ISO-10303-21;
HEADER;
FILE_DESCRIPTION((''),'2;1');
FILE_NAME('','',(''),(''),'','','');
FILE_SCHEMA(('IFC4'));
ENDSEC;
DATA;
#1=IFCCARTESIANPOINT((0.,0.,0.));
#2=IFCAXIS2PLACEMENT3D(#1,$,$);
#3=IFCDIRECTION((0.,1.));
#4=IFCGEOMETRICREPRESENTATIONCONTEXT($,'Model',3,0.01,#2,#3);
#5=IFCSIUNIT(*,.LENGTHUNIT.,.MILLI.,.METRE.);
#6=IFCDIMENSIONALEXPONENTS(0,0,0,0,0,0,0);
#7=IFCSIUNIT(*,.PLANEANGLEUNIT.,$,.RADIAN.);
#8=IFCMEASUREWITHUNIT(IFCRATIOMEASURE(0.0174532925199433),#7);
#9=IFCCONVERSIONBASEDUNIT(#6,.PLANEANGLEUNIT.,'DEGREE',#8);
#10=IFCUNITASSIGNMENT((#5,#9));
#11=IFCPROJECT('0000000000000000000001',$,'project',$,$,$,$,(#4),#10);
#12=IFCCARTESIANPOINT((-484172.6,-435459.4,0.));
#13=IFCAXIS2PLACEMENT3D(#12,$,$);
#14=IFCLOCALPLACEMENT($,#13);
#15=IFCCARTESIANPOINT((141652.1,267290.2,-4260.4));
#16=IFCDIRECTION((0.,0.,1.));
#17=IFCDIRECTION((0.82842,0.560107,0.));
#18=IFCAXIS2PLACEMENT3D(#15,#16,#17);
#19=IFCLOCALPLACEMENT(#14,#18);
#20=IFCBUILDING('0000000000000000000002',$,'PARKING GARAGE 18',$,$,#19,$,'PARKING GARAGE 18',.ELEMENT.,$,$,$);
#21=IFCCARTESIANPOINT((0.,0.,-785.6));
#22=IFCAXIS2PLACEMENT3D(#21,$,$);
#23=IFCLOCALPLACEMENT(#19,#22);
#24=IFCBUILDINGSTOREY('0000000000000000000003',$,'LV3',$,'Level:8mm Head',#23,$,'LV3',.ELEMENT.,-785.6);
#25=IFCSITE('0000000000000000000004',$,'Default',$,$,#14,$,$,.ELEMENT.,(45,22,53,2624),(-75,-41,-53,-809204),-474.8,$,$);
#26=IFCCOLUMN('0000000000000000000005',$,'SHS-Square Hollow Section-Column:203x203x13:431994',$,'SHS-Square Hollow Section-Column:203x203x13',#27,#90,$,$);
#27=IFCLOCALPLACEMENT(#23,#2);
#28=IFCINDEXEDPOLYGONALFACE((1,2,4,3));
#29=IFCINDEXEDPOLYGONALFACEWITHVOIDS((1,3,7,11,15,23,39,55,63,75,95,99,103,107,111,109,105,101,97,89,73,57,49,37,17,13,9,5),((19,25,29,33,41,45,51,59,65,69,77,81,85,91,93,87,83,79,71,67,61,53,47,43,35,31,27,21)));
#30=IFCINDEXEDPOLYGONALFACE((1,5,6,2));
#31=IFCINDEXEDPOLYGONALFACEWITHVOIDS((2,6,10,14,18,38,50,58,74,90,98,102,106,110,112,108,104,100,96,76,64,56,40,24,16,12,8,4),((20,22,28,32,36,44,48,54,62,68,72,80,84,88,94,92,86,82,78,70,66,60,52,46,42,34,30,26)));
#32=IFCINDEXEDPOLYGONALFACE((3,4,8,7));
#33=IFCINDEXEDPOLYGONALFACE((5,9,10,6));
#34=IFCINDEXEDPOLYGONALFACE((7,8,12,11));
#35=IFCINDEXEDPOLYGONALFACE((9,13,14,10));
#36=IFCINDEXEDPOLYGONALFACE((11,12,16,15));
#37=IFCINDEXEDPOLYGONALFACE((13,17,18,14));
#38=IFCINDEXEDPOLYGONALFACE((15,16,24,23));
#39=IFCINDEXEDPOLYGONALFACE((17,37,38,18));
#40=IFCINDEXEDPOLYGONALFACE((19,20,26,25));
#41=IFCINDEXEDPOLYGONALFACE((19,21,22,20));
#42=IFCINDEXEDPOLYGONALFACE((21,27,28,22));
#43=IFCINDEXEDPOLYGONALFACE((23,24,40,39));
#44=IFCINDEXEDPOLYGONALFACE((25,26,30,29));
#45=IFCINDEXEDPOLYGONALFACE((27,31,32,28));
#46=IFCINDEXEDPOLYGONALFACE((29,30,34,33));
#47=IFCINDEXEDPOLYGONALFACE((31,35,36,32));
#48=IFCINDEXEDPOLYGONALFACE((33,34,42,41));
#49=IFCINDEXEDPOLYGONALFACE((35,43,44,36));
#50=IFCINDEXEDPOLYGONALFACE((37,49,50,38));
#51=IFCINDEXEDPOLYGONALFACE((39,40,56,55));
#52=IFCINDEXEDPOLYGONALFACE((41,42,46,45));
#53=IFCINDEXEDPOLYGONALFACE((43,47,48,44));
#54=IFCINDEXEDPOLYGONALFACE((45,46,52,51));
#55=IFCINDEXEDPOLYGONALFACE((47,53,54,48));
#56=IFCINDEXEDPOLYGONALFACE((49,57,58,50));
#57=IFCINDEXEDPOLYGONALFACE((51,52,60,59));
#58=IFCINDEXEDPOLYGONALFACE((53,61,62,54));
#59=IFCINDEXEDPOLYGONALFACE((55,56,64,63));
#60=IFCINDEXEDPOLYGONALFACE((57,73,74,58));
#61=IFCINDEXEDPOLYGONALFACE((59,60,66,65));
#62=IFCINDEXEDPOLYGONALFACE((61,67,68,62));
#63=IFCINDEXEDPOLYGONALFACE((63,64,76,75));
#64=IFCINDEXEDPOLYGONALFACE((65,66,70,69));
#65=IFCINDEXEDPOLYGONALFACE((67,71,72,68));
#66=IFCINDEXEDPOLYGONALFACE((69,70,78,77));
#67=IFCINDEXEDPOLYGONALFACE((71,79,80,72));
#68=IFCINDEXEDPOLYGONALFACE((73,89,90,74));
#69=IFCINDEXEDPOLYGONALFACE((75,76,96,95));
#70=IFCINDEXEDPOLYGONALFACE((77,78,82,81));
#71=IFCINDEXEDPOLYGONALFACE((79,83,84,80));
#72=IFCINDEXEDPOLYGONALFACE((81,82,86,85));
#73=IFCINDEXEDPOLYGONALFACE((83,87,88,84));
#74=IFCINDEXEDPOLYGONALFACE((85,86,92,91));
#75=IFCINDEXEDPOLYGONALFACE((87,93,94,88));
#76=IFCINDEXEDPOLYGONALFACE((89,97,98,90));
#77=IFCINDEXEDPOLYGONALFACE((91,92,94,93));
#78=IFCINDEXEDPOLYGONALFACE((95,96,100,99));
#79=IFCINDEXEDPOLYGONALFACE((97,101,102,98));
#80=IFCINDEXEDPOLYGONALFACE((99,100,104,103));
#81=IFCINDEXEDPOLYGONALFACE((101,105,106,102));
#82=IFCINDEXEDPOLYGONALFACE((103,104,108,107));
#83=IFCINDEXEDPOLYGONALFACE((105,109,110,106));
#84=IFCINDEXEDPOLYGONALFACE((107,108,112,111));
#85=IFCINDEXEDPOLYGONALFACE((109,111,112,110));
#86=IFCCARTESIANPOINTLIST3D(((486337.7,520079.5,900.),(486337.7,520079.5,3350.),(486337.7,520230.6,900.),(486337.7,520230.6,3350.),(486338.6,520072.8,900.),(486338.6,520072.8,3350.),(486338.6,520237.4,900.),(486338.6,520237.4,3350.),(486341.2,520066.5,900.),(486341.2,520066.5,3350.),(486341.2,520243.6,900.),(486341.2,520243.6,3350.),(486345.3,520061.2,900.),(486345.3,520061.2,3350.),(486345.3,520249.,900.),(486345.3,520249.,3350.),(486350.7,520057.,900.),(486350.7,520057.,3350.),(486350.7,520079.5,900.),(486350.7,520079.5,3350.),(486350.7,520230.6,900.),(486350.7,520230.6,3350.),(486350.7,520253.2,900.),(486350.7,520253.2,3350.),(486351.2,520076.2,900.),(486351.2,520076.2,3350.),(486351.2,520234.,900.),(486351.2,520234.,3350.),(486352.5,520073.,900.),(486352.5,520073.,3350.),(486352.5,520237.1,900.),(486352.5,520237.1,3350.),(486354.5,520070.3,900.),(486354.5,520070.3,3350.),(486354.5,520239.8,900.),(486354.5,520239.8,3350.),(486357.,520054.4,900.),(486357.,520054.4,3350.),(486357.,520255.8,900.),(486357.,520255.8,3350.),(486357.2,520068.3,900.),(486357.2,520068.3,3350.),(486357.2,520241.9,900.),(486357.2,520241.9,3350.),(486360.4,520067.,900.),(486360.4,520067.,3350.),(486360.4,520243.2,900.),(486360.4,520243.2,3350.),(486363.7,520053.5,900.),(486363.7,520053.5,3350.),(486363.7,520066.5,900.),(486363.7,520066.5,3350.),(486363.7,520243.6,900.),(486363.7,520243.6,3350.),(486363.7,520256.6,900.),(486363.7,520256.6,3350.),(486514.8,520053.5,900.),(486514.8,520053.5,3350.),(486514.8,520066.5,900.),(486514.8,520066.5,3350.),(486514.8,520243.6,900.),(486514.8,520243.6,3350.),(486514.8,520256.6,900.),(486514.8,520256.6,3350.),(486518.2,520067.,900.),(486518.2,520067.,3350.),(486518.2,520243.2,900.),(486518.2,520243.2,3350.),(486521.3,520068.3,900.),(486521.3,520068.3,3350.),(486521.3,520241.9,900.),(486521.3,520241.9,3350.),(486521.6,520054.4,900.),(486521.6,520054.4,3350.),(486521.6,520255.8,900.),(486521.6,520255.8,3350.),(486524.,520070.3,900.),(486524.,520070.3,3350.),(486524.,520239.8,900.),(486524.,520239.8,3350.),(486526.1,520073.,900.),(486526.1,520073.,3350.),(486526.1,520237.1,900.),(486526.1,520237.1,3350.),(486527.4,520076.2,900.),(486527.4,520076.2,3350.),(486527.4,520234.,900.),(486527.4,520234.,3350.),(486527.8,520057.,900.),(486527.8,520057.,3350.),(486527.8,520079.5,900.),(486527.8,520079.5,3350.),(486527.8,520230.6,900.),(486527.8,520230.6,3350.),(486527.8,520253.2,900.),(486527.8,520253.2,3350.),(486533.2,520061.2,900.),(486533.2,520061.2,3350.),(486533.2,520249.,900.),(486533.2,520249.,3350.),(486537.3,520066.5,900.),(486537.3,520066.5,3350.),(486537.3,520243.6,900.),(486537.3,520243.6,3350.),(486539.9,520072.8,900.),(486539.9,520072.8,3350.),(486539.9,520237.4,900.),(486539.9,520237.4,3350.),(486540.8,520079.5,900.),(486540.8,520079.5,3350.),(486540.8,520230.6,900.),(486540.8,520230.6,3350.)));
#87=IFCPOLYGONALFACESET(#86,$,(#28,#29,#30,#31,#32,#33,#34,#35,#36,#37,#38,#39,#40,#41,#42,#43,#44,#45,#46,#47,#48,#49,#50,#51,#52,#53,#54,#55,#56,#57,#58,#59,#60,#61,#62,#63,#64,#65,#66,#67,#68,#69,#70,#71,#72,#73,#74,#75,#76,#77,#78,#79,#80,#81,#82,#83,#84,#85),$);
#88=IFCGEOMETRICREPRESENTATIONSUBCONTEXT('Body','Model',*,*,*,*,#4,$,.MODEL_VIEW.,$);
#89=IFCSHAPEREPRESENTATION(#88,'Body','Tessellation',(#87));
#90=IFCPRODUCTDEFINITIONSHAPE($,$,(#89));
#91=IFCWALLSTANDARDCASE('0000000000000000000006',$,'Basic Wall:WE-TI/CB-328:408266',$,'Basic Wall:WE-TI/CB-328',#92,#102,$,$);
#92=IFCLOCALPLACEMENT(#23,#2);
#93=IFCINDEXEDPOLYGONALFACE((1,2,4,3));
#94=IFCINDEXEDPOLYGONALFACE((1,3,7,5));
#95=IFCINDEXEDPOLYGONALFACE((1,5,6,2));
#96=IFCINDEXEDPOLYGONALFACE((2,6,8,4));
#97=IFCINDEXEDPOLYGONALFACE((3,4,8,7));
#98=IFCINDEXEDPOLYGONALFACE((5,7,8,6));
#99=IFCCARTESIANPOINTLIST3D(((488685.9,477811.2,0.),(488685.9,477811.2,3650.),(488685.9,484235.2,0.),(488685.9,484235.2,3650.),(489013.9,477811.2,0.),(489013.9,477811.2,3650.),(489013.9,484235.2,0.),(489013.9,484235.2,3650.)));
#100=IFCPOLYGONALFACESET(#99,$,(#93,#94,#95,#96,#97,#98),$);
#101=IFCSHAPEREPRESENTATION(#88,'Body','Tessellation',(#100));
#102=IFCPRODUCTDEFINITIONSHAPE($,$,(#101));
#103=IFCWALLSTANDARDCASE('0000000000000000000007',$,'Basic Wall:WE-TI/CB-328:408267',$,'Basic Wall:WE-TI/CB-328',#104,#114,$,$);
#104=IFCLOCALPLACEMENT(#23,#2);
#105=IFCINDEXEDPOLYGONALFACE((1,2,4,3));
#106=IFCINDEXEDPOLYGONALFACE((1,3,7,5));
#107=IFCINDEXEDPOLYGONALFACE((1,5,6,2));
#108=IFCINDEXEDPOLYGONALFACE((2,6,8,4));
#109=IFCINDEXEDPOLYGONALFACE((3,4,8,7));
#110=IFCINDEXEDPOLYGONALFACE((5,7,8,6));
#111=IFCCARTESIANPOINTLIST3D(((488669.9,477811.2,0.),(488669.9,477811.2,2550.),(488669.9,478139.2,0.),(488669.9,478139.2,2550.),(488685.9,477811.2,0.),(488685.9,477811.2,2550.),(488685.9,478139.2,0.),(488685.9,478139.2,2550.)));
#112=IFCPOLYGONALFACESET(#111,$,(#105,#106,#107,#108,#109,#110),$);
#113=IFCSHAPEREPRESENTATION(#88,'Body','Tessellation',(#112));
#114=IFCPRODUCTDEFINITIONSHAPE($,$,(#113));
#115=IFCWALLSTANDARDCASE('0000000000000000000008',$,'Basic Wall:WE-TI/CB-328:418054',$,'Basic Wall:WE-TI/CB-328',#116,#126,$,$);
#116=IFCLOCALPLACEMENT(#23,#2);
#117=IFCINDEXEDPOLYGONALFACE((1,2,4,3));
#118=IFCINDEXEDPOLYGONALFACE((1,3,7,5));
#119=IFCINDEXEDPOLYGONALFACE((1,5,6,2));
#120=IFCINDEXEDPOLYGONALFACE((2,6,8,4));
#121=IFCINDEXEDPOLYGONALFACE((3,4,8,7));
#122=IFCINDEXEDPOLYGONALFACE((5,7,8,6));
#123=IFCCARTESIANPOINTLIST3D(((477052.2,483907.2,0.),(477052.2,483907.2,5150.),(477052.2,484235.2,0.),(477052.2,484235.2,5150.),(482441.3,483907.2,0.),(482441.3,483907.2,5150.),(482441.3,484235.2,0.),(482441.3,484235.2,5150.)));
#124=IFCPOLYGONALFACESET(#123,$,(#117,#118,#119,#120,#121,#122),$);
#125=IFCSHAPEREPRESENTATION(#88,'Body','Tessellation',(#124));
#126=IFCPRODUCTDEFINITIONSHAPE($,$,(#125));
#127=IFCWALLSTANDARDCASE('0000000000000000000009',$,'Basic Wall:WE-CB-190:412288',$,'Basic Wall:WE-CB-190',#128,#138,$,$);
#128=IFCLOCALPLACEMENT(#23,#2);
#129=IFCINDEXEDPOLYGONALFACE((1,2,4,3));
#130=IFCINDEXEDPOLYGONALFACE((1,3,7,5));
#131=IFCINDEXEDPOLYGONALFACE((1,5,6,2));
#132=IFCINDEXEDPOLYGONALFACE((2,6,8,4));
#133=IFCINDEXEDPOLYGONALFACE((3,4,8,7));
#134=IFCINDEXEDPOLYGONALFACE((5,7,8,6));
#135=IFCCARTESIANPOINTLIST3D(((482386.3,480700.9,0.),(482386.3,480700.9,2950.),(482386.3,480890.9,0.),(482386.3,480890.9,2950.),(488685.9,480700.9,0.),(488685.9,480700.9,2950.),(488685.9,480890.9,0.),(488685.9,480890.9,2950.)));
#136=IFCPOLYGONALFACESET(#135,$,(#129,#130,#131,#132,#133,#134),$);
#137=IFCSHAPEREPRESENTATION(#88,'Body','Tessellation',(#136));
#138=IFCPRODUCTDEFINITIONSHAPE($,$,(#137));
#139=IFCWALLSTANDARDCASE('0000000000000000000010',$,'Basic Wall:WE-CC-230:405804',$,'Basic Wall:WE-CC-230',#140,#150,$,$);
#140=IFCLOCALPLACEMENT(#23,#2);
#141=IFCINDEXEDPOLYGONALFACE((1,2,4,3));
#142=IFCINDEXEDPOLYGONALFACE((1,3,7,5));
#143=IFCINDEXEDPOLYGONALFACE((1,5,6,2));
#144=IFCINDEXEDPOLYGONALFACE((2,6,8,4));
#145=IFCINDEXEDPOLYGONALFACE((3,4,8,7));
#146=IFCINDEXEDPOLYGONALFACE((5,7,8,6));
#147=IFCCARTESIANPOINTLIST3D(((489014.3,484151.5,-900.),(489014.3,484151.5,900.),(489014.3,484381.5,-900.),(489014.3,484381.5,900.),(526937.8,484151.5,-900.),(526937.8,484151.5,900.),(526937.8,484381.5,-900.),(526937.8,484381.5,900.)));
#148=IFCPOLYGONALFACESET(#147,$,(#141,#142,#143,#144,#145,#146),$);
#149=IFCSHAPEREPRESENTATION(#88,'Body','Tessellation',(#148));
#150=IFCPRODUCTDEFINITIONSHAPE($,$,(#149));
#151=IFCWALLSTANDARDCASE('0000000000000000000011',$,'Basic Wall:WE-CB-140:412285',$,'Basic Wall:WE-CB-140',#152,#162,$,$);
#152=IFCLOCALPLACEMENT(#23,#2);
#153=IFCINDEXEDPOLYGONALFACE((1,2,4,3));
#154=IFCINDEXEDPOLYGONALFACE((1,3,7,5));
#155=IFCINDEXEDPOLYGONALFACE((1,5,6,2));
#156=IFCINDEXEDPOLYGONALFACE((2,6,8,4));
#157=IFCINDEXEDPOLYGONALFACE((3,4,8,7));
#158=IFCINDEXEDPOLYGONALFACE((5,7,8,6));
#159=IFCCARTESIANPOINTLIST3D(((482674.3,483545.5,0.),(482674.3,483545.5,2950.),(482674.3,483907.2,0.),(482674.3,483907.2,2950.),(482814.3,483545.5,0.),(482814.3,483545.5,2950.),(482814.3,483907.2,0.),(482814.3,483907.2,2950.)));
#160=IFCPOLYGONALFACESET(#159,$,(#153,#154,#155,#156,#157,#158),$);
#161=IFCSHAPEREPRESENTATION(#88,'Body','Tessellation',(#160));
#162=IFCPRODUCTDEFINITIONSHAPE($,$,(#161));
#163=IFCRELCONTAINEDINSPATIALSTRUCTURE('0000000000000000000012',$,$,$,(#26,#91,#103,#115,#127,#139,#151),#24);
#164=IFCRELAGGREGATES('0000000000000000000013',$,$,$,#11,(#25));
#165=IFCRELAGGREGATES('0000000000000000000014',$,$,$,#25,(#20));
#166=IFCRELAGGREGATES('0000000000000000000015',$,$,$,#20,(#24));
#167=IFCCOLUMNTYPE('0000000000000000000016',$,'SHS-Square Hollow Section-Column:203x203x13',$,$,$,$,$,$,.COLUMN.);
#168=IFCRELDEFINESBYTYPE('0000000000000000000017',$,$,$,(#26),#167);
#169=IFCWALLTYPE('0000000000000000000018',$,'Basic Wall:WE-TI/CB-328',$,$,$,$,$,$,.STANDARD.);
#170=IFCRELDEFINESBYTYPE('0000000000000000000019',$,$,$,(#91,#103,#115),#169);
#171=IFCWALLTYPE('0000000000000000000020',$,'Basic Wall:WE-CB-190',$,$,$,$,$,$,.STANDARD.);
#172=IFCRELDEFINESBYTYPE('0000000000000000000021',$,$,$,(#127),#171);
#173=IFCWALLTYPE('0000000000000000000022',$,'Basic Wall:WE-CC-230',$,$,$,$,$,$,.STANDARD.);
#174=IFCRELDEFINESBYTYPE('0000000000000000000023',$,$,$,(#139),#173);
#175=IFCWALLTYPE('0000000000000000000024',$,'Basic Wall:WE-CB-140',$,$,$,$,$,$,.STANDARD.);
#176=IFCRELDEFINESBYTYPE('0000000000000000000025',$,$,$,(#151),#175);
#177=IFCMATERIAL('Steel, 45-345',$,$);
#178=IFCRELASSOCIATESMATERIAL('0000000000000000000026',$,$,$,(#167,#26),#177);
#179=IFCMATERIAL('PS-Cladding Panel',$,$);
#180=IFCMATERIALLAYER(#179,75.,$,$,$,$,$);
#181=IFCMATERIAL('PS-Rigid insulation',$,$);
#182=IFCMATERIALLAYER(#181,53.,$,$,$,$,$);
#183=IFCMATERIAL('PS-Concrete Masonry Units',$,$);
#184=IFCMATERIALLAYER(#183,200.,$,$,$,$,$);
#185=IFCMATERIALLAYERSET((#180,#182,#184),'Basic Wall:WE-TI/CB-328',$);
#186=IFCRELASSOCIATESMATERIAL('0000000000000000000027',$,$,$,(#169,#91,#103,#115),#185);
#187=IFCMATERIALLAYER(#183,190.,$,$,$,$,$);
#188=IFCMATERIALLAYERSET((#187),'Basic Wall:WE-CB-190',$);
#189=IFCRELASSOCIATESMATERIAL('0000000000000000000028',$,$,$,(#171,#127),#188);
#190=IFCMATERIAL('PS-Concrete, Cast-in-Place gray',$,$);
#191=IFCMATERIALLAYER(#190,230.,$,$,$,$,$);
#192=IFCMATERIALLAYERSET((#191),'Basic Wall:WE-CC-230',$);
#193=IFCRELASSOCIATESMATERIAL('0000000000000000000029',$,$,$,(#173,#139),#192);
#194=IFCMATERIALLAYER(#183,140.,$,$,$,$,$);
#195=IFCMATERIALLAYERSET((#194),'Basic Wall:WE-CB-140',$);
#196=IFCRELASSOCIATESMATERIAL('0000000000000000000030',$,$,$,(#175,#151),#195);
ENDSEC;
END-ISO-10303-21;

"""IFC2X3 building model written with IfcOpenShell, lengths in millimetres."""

from ifc_helpers import new_model, entity, si_unit, converted_unit, direction, frame, frame_2d, origin, place, context, subcontext, project, spatial, polyline, circle_curve, parameter, trimmed, segment, composite_curve, rectangle, outline, extrude, clip, bounded_halfspace, source, transform, mapped, material, layer, layer_set, layer_usage, type_object, type_shapes, element, save


model = new_model("IFC2X3")

# Units and contexts
model_context = context("Model", 3, precision=0.01, world=origin(), true_north=direction((0.0, 1.0)))
body_context = subcontext(model_context, "Body", "Model", "MODEL_VIEW")
ifc_project = project(units=[si_unit("LENGTHUNIT", "METRE", prefix="MILLI"), converted_unit("PLANEANGLEUNIT", "DEGREE", entity("IfcRatioMeasure", 0.0174532925199433), si_unit("PLANEANGLEUNIT", "RADIAN"), dimensions=[0, 0, 0, 0, 0, 0, 0])], contexts=[model_context])

# Site, building, storey
site_placement = place(None, frame((-484172.6, -435459.4, 0.0)))
site = spatial("IfcSite", under=ifc_project, at=site_placement, Name="Default", CompositionType="ELEMENT", RefLatitude=(45, 22, 53, 2624), RefLongitude=(-75, -41, -53, -809204), RefElevation=-474.8)
building_placement = place(site_placement, frame((141652.1, 267290.2, -4260.4), z_axis=(0.0, 0.0, 1.0), x_axis=(0.82842, 0.560107, 0.0)))
building = spatial("IfcBuilding", under=site, at=building_placement, Name="PARKING GARAGE 18", LongName="PARKING GARAGE 18", CompositionType="ELEMENT")
storey_placement = place(building_placement, frame((0.0, 0.0, -785.6)))
storey = spatial("IfcBuildingStorey", under=building, at=storey_placement, Name="LV3", ObjectType="Level:8mm Head", LongName="LV3", CompositionType="ELEMENT", Elevation=-785.6)

# Column
ifc_material_1 = material(Name="Steel, 45-345")
column_type_1 = type_object("IfcColumnType", Name="SHS-Square Hollow Section-Column:203x203x13", PredefinedType="COLUMN", material=ifc_material_1)
shared_shape_1 = source(origin(), body_context, "Body", "SweptSolid", [
    extrude(outline(composite_curve([segment(polyline([(-75.6, -101.5), (75.6, -101.5)]), True, "CONTINUOUS"), segment(trimmed(circle_curve(frame_2d((75.6, -75.6), x_axis=(-1.0, 0.0)), 26.0), [parameter(90.0)], [parameter(180.0)], True, "PARAMETER"), True, "CONTINUOUS"), segment(polyline([(101.5, -75.6), (101.5, 75.6)]), True, "CONTINUOUS"), segment(trimmed(circle_curve(frame_2d((75.5, 75.6), x_axis=(-1.0, 0.0)), 26.0), [parameter(180.0)], [parameter(270.0)], True, "PARAMETER"), True, "CONTINUOUS"), segment(polyline([(75.5, 101.6), (-75.5, 101.6)]), True, "CONTINUOUS"), segment(trimmed(circle_curve(frame_2d((-75.5, 75.5), x_axis=(-1.0, 0.0)), 26.0), [parameter(270.0)], [parameter(360.0)], True, "PARAMETER"), True, "CONTINUOUS"), segment(polyline([(-101.5, 75.5), (-101.5, -75.6)]), True, "CONTINUOUS"), segment(trimmed(circle_curve(frame_2d((-75.6, -75.6), x_axis=(-1.0, 0.0)), 26.0), [parameter(360.0)], [parameter(90.0)], True, "PARAMETER"), True, "CONTINUOUS")], self_intersect=False), holes=[composite_curve([segment(trimmed(circle_curve(frame_2d((-75.6, -75.6), x_axis=(-1.0, 0.0)), 13.0), [parameter(0.0)], [parameter(90.0)], True, "PARAMETER"), False, "CONTINUOUS"), segment(polyline([(-88.5, -75.6), (-88.5, 75.6)]), True, "CONTINUOUS"), segment(trimmed(circle_curve(frame_2d((-75.6, 75.6), x_axis=(-1.0, 0.0)), 13.0), [parameter(270.0)], [parameter(0.0)], True, "PARAMETER"), False, "CONTINUOUS"), segment(polyline([(-75.6, 88.6), (75.5, 88.6)]), True, "CONTINUOUS"), segment(trimmed(circle_curve(frame_2d((75.5, 75.5), x_axis=(-1.0, 0.0)), 13.0), [parameter(180.0)], [parameter(270.0)], True, "PARAMETER"), False, "CONTINUOUS"), segment(polyline([(88.6, 75.5), (88.6, -75.5)]), True, "CONTINUOUS"), segment(trimmed(circle_curve(frame_2d((75.6, -75.5), x_axis=(-1.0, 0.0)), 13.0), [parameter(90.0)], [parameter(180.0)], True, "PARAMETER"), False, "CONTINUOUS"), segment(polyline([(75.6, -88.5), (-75.6, -88.5)]), True, "CONTINUOUS")], self_intersect=False)]), frame((0.0, 0.0, 114.4), z_axis=(0.0, 0.0, 1.0), x_axis=(-1.0, 0.0, 0.0)), (0.0, 0.0, 1.0), 2450.0),
])
type_shapes(column_type_1, [shared_shape_1])
column_placement = place(storey_placement, frame((486439.3, 520155.1, 785.6)))
element("IfcColumn", 1, at=column_placement, inside=storey, type_object=column_type_1, material=ifc_material_1, Name="SHS-Square Hollow Section-Column:203x203x13:431994", ObjectType="SHS-Square Hollow Section-Column:203x203x13", context=body_context, shape_type="MappedRepresentation", body=[
    mapped(shared_shape_1, transform((0.0, 0.0, 0.0), scale=1.0)),
])

# Walls
ifc_material_2 = material(Name="PS-Cladding Panel")
ifc_layer_1 = layer(ifc_material_2, 75.0)
ifc_material_3 = material(Name="PS-Rigid insulation")
ifc_layer_2 = layer(ifc_material_3, 53.0)
ifc_material_4 = material(Name="PS-Concrete Masonry Units")
ifc_layer_3 = layer(ifc_material_4, 200.0)
ifc_layer_set_1 = layer_set([ifc_layer_1, ifc_layer_2, ifc_layer_3], Name="Basic Wall:WE-TI/CB-328")
ifc_layer_usage_1 = layer_usage(ifc_layer_set_1, "AXIS2", "NEGATIVE", 164.0)
wall_type_1 = type_object("IfcWallType", Name="Basic Wall:WE-TI/CB-328", PredefinedType="STANDARD", material=ifc_layer_set_1)
wall_1_placement = place(storey_placement, frame((488849.9, 484235.2, 0.0), z_axis=(0.0, 0.0, 1.0), x_axis=(0.0, -1.0, 0.0)))
element("IfcWallStandardCase", 2, at=wall_1_placement, inside=storey, type_object=wall_type_1, material=ifc_layer_usage_1, Name="Basic Wall:WE-TI/CB-328:408266", ObjectType="Basic Wall:WE-TI/CB-328", context=body_context, shape_type="SweptSolid", body=[
    extrude(rectangle(XDim=6424.0, YDim=328.0, at=frame_2d((3212.0, 0.0), x_axis=(-1.0, 0.0))), origin(), (0.0, 0.0, 1.0), 3650.0),
])
ifc_layer_usage_2 = layer_usage(ifc_layer_set_1, "AXIS2", "NEGATIVE", 164.0)
wall_2_placement = place(storey_placement, frame((488685.9, 477975.2, 0.0), z_axis=(0.0, 0.0, 1.0), x_axis=(-1.0, 0.0, 0.0)))
element("IfcWallStandardCase", 3, at=wall_2_placement, inside=storey, type_object=wall_type_1, material=ifc_layer_usage_2, Name="Basic Wall:WE-TI/CB-328:408267", ObjectType="Basic Wall:WE-TI/CB-328", context=body_context, shape_type="Clipping", body=[
    clip(extrude(rectangle(XDim=16.0, YDim=328.0, at=frame_2d((8.0, 0.0), x_axis=(-1.0, 0.0))), origin(), (0.0, 0.0, 1.0), 2550.0), bounded_halfspace(frame((0.0, -164.0, 2550.0), z_axis=(0.0, 0.0, -1.0), x_axis=(0.0, -1.0, 0.0)), True, frame((0.0, -164.0, 2550.0), z_axis=(0.0, 0.0, -1.0), x_axis=(0.0, -1.0, 0.0)), polyline([(0.0, 0.0), (-328.0, 0.0), (-328.0, -16.0), (0.0, -16.0), (0.0, 0.0)]))),
])
ifc_layer_usage_3 = layer_usage(ifc_layer_set_1, "AXIS2", "NEGATIVE", 164.0)
wall_3_placement = place(storey_placement, frame((477052.2, 484071.2, 0.0)))
element("IfcWallStandardCase", 4, at=wall_3_placement, inside=storey, type_object=wall_type_1, material=ifc_layer_usage_3, Name="Basic Wall:WE-TI/CB-328:418054", ObjectType="Basic Wall:WE-TI/CB-328", context=body_context, shape_type="SweptSolid", body=[
    extrude(rectangle(XDim=5389.1, YDim=328.0, at=frame_2d((2694.5, 0.0), x_axis=(-1.0, 0.0))), origin(), (0.0, 0.0, 1.0), 5150.0),
])
ifc_layer_4 = layer(ifc_material_4, 190.0)
ifc_layer_set_2 = layer_set([ifc_layer_4], Name="Basic Wall:WE-CB-190")
ifc_layer_usage_4 = layer_usage(ifc_layer_set_2, "AXIS2", "NEGATIVE", 95.0)
wall_type_2 = type_object("IfcWallType", Name="Basic Wall:WE-CB-190", PredefinedType="STANDARD", material=ifc_layer_set_2)
wall_4_placement = place(storey_placement, frame((482386.3, 480795.9, 0.0)))
element("IfcWallStandardCase", 5, at=wall_4_placement, inside=storey, type_object=wall_type_2, material=ifc_layer_usage_4, Name="Basic Wall:WE-CB-190:412288", ObjectType="Basic Wall:WE-CB-190", context=body_context, shape_type="SweptSolid", body=[
    extrude(rectangle(XDim=6299.6, YDim=190.0, at=frame_2d((3149.8, 0.0), x_axis=(-1.0, 0.0))), origin(), (0.0, 0.0, 1.0), 2950.0),
])
ifc_material_5 = material(Name="PS-Concrete, Cast-in-Place gray")
ifc_layer_5 = layer(ifc_material_5, 230.0)
ifc_layer_set_3 = layer_set([ifc_layer_5], Name="Basic Wall:WE-CC-230")
ifc_layer_usage_5 = layer_usage(ifc_layer_set_3, "AXIS2", "POSITIVE", -115.0)
wall_type_3 = type_object("IfcWallType", Name="Basic Wall:WE-CC-230", PredefinedType="STANDARD", material=ifc_layer_set_3)
wall_5_placement = place(storey_placement, frame((489014.3, 484266.5, -900.0)))
element("IfcWallStandardCase", 6, at=wall_5_placement, inside=storey, type_object=wall_type_3, material=ifc_layer_usage_5, Name="Basic Wall:WE-CC-230:405804", ObjectType="Basic Wall:WE-CC-230", context=body_context, shape_type="SweptSolid", body=[
    extrude(rectangle(XDim=37923.5, YDim=230.0, at=frame_2d((18961.7, 0.0), x_axis=(-1.0, 0.0))), origin(), (0.0, 0.0, 1.0), 1800.0),
])
ifc_layer_6 = layer(ifc_material_4, 140.0)
ifc_layer_set_4 = layer_set([ifc_layer_6], Name="Basic Wall:WE-CB-140")
ifc_layer_usage_6 = layer_usage(ifc_layer_set_4, "AXIS2", "NEGATIVE", 70.0)
wall_type_4 = type_object("IfcWallType", Name="Basic Wall:WE-CB-140", PredefinedType="STANDARD", material=ifc_layer_set_4)
wall_6_placement = place(storey_placement, frame((482744.3, 483545.5, 0.0), z_axis=(0.0, 0.0, 1.0), x_axis=(0.0, 1.0, 0.0)))
element("IfcWallStandardCase", 7, at=wall_6_placement, inside=storey, type_object=wall_type_4, material=ifc_layer_usage_6, Name="Basic Wall:WE-CB-140:412285", ObjectType="Basic Wall:WE-CB-140", context=body_context, shape_type="SweptSolid", body=[
    extrude(rectangle(XDim=361.7, YDim=140.0, at=frame_2d((180.8, 0.0), x_axis=(-1.0, 0.0))), origin(), (0.0, 0.0, 1.0), 2950.0),
])

save(model, "model.ifc")
